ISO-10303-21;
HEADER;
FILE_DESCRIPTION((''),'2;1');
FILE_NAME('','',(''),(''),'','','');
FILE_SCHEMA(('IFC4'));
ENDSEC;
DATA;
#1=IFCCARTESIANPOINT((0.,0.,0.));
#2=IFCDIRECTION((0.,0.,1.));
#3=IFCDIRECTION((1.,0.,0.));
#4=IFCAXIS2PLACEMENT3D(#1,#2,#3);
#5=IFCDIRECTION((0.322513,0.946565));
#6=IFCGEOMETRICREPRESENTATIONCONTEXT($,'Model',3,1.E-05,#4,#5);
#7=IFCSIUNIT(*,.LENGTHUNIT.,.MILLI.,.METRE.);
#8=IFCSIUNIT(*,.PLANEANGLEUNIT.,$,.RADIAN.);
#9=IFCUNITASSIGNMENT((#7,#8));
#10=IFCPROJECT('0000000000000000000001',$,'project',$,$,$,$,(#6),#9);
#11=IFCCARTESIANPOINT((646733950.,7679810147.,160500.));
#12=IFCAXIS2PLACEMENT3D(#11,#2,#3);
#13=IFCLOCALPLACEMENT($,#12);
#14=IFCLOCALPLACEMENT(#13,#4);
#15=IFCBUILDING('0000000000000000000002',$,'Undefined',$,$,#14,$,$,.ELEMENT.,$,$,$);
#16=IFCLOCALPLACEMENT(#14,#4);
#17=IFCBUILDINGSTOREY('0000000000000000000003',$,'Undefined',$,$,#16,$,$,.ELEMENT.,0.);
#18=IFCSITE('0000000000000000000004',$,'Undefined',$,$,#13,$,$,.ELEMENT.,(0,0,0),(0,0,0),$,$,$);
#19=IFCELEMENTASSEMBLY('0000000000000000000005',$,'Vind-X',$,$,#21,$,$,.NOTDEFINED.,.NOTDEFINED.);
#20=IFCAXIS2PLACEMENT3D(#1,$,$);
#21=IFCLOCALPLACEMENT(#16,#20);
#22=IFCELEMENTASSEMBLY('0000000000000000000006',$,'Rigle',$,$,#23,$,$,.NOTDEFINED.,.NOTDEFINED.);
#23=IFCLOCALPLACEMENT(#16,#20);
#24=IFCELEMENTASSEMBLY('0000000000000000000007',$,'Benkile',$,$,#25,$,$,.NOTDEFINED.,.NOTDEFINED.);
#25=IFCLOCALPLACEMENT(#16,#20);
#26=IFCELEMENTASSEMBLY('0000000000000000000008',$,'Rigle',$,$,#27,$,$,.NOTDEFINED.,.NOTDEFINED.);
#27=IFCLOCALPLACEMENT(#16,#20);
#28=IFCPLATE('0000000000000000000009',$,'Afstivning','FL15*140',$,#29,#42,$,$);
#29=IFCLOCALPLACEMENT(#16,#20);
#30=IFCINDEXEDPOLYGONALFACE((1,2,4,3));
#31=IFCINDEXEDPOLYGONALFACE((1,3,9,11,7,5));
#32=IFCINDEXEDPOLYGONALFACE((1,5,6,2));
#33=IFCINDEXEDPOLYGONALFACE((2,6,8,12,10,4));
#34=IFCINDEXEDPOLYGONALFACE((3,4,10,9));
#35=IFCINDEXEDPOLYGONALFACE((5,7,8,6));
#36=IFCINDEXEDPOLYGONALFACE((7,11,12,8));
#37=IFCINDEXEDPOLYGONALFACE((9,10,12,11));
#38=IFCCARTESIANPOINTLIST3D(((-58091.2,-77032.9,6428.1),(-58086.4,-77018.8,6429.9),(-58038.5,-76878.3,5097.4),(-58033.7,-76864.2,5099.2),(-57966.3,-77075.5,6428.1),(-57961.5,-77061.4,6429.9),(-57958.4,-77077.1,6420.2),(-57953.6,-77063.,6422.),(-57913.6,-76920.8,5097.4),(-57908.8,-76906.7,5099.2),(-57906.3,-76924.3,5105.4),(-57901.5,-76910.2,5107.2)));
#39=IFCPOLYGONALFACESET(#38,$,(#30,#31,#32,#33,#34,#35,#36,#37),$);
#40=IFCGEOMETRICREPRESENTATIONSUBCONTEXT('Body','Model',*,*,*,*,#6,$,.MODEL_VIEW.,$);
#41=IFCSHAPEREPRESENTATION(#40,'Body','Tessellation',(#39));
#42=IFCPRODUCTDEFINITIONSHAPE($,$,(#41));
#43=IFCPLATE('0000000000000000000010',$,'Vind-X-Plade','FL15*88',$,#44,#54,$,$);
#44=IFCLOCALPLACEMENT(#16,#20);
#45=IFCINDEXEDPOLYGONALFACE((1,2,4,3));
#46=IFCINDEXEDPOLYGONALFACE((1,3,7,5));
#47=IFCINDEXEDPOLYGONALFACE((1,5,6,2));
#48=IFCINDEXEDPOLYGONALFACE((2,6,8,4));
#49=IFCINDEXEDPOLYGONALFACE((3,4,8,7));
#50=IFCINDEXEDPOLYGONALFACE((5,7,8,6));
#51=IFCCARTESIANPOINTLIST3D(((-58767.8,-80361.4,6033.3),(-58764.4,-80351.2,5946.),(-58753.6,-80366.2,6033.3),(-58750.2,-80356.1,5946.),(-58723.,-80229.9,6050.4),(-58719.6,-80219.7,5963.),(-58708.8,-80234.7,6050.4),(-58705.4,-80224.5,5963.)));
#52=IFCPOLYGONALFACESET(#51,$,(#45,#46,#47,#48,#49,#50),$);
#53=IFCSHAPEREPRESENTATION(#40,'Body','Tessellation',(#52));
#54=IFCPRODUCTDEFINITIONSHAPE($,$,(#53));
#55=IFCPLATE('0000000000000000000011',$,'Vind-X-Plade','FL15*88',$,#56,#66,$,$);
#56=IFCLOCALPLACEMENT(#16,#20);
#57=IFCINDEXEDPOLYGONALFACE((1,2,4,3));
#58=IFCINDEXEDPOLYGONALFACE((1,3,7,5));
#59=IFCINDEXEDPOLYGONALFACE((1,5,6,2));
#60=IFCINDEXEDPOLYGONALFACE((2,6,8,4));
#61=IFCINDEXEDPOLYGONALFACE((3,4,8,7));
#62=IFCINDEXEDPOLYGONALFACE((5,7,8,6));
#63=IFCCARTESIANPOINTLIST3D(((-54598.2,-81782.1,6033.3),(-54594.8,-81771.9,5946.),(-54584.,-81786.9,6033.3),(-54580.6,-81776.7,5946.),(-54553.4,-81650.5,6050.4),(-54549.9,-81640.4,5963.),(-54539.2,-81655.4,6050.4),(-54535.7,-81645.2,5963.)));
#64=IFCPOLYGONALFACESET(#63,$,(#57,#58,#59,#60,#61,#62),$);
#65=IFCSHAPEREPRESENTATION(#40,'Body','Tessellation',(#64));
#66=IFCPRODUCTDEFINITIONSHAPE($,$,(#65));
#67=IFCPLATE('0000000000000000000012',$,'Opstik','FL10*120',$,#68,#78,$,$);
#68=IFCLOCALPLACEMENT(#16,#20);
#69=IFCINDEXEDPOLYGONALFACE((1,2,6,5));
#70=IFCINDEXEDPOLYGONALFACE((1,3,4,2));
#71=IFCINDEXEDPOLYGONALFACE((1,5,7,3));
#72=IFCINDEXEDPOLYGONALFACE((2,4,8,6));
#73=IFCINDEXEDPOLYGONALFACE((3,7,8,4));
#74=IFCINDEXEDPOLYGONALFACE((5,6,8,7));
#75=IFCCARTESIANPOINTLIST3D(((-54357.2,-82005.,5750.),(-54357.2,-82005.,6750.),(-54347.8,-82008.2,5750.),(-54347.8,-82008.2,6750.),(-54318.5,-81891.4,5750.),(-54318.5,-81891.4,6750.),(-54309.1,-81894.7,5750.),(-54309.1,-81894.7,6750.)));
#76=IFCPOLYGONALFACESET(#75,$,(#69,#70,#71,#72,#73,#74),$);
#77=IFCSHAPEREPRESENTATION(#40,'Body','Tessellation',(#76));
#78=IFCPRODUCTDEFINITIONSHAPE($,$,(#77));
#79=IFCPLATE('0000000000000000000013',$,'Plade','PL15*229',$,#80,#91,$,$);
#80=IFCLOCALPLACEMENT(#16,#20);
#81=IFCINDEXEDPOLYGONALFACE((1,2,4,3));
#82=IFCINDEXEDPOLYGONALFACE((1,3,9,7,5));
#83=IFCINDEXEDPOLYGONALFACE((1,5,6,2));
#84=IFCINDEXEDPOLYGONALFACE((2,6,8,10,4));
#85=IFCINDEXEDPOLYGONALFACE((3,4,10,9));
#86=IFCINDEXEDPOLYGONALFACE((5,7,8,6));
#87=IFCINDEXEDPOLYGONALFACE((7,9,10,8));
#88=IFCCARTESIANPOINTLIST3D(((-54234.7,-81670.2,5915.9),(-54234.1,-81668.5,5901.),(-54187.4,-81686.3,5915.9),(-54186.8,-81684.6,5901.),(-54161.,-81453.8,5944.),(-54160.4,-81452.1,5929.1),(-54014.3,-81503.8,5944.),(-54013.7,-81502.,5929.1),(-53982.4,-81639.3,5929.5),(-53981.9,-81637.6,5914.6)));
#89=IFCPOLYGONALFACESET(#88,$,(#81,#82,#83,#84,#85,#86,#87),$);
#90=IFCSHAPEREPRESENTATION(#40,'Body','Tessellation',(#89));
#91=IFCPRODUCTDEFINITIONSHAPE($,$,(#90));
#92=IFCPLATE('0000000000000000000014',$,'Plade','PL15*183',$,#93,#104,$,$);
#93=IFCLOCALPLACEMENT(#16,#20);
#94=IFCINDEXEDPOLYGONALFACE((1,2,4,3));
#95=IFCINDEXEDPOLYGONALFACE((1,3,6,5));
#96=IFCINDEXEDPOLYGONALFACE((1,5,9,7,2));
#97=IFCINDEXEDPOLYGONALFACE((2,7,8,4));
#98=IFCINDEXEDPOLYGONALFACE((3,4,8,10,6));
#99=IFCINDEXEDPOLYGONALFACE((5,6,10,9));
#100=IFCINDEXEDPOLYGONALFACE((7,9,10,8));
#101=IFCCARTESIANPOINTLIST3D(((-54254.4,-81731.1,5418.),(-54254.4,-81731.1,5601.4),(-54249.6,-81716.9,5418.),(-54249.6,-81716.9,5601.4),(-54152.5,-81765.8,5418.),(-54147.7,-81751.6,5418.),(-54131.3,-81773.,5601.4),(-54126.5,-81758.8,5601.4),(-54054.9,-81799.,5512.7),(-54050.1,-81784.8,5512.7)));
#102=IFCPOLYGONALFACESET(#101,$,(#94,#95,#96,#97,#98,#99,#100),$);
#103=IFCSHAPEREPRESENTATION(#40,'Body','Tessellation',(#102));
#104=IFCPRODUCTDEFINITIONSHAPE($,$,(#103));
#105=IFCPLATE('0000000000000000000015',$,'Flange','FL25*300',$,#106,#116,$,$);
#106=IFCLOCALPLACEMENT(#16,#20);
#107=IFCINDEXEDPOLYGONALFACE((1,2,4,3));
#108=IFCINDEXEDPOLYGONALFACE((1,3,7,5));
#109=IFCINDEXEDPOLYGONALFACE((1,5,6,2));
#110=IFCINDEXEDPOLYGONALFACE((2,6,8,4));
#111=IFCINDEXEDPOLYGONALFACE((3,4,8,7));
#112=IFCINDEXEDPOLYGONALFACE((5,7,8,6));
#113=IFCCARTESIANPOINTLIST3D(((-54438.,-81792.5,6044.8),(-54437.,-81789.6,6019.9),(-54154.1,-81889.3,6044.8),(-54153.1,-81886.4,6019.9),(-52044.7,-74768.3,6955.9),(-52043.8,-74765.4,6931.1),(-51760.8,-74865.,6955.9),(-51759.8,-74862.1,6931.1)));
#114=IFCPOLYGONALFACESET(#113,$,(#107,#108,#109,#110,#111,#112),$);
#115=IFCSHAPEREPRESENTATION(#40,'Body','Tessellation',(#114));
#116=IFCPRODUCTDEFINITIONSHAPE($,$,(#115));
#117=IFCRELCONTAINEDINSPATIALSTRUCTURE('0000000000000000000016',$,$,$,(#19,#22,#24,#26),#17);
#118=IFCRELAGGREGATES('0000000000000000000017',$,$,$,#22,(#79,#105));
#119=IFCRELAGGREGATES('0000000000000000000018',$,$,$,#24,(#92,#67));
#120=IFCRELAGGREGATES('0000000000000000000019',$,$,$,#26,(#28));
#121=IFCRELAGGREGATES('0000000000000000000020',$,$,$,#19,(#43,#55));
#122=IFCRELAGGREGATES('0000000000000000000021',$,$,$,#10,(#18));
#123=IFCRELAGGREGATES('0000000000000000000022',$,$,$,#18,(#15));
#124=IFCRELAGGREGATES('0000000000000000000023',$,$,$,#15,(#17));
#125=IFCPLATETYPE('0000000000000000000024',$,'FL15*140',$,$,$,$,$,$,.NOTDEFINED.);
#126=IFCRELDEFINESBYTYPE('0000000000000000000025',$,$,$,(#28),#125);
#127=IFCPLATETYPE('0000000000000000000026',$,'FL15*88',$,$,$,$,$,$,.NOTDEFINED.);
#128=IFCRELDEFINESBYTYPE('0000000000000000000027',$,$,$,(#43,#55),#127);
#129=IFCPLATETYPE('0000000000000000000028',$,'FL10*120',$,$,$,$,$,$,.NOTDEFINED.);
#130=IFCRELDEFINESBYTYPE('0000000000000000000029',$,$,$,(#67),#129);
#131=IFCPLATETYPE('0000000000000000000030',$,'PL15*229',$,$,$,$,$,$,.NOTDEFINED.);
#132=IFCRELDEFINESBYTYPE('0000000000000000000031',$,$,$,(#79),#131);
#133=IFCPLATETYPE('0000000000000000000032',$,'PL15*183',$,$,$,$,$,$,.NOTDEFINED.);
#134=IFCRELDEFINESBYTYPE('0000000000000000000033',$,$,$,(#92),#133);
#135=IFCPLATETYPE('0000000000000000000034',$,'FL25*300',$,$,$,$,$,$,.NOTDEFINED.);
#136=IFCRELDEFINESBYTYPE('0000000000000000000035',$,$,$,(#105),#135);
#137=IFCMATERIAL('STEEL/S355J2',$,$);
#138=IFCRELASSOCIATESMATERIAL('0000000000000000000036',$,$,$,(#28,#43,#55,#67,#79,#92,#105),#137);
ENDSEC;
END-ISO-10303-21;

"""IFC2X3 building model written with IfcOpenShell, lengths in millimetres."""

from ifc_helpers import new_model, si_unit, direction, frame, origin_with_axes, place, context, subcontext, project, spatial, polyline, outline, extrude, clip, halfspace, material, type_object, element, aggregate, save


model = new_model("IFC2X3")

# Units and contexts
model_context = context("Model", 3, precision=1e-05, world=origin_with_axes(), true_north=direction((0.322513, 0.946565)))
body_context = subcontext(model_context, "Body", "Model", "MODEL_VIEW")
ifc_project = project(units=[si_unit("LENGTHUNIT", "METRE", prefix="MILLI"), si_unit("PLANEANGLEUNIT", "RADIAN")], contexts=[model_context])

# Site, building, storey
site_placement = place(None, frame((646733950.0, 7679810147.0, 160500.0), z_axis=(0.0, 0.0, 1.0), x_axis=(1.0, 0.0, 0.0)))
site = spatial("IfcSite", under=ifc_project, at=site_placement, Name="Undefined", CompositionType="ELEMENT", RefLatitude=(0, 0, 0), RefLongitude=(0, 0, 0))
building_placement = place(site_placement, origin_with_axes())
building = spatial("IfcBuilding", under=site, at=building_placement, Name="Undefined", CompositionType="ELEMENT")
storey_placement = place(building_placement, origin_with_axes())
storey = spatial("IfcBuildingStorey", under=building, at=storey_placement, Name="Undefined", CompositionType="ELEMENT", Elevation=0.0)

# Element assembly
assembly_1_placement = place(storey_placement, origin_with_axes())
assembly_1 = element("IfcElementAssembly", 1, at=assembly_1_placement, inside=storey, Name="Vind-X", AssemblyPlace="NOTDEFINED", PredefinedType="NOTDEFINED")

# Shared definitions
ifc_material_1 = material(Name="STEEL/S355J2")

# Element assemblies
assembly_2_placement = place(storey_placement, origin_with_axes())
assembly_2 = element("IfcElementAssembly", 2, at=assembly_2_placement, inside=storey, Name="Rigle", AssemblyPlace="NOTDEFINED", PredefinedType="NOTDEFINED")
assembly_3_placement = place(storey_placement, origin_with_axes())
assembly_3 = element("IfcElementAssembly", 3, at=assembly_3_placement, inside=storey, Name="Benkile", AssemblyPlace="NOTDEFINED", PredefinedType="NOTDEFINED")

# Shared definitions
plate_type_1 = type_object("IfcPlateType", Name="FL15*140", PredefinedType="NOTDEFINED")

# Element assembly, plate
assembly_4_placement = place(storey_placement, origin_with_axes())
assembly_4 = element("IfcElementAssembly", 4, at=assembly_4_placement, inside=storey, Name="Rigle", AssemblyPlace="NOTDEFINED", PredefinedType="NOTDEFINED")
plate_1_placement = place(assembly_4_placement, frame((-57903.6, -76916.4, 5098.3), z_axis=(0.320109, 0.93951, 0.121869), x_axis=(-0.946565, 0.322513, 0.0)))
plate_1 = element("IfcPlate", 5, at=plate_1_placement, type_object=plate_type_1, material=ifc_material_1, Name="Afstivning", Description="FL15*140", context=body_context, shape_type="SweptSolid", body=[
    extrude(outline(polyline([(0.0, 8.0), (8.0, 0.0), (140.0, 0.0), (140.0, 1340.7), (8.0, 1340.7), (0.0, 1332.7), (0.0, 8.0)])), frame((0.0, 0.0, -7.5), z_axis=(0.0, 0.0, 1.0), x_axis=(1.0, 0.0, 0.0)), (0.0, 0.0, 1.0), 15.0),
])

# Plates
plate_type_2 = type_object("IfcPlateType", Name="FL15*88", PredefinedType="NOTDEFINED")
plate_2_placement = place(assembly_1_placement, frame((-58712.5, -80222.1, 5963.0), z_axis=(-0.946565, 0.322513, 0.0), x_axis=(-0.320109, -0.93951, -0.121869)))
plate_2 = element("IfcPlate", 6, at=plate_2_placement, type_object=plate_type_2, material=ifc_material_1, Name="Vind-X-Plade", Description="FL15*88", context=body_context, shape_type="SweptSolid", body=[
    extrude(outline(polyline([(0.0, 0.0), (140.0, 0.0), (140.0, 88.0), (0.0, 88.0), (0.0, 0.0)])), frame((0.0, 0.0, -7.5), z_axis=(0.0, 0.0, 1.0), x_axis=(1.0, 0.0, 0.0)), (0.0, 0.0, 1.0), 15.0),
])
plate_3_placement = place(assembly_1_placement, frame((-54542.8, -81642.8, 5963.0), z_axis=(-0.946565, 0.322513, 0.0), x_axis=(-0.320109, -0.93951, -0.121869)))
plate_3 = element("IfcPlate", 7, at=plate_3_placement, type_object=plate_type_2, material=ifc_material_1, Name="Vind-X-Plade", Description="FL15*88", context=body_context, shape_type="SweptSolid", body=[
    extrude(outline(polyline([(0.0, 0.0), (140.0, 0.0), (140.0, 88.0), (0.0, 88.0), (0.0, 0.0)])), frame((0.0, 0.0, -7.5), z_axis=(0.0, 0.0, 1.0), x_axis=(1.0, 0.0, 0.0)), (0.0, 0.0, 1.0), 15.0),
])
plate_type_3 = type_object("IfcPlateType", Name="FL10*120", PredefinedType="NOTDEFINED")
plate_4_placement = place(assembly_3_placement, frame((-54313.8, -81893.0, 5750.0), z_axis=(0.946565, -0.322513, 0.0), x_axis=(0.0, 0.0, 1.0)))
plate_4 = element("IfcPlate", 8, at=plate_4_placement, type_object=plate_type_3, material=ifc_material_1, Name="Opstik", Description="FL10*120", context=body_context, shape_type="SweptSolid", body=[
    extrude(outline(polyline([(0.0, 0.0), (1000.0, 0.0), (1000.0, 120.0), (1000.0, 120.0), (0.0, 120.0), (0.0, 120.0), (0.0, 0.0)])), frame((0.0, 0.0, -5.0), z_axis=(0.0, 0.0, 1.0), x_axis=(1.0, 0.0, 0.0)), (0.0, 0.0, 1.0), 10.0),
])
plate_type_4 = type_object("IfcPlateType", Name="PL15*229", PredefinedType="NOTDEFINED")
plate_5_placement = place(assembly_2_placement, frame((-54160.7, -81452.9, 5936.5), z_axis=(-0.039304, -0.115357, 0.992546), x_axis=(-0.320109, -0.93951, -0.121869)))
plate_5 = element("IfcPlate", 9, at=plate_5_placement, type_object=plate_type_4, material=ifc_material_1, Name="Plade", Description="PL15*229", context=body_context, shape_type="SweptSolid", body=[
    extrude(outline(polyline([(0.0, 0.0), (230.3, 0.0), (230.3, 50.0), (118.9, 228.8), (0.0, 154.9), (0.0, 0.0)])), frame((0.0, 0.0, -7.5), z_axis=(0.0, 0.0, 1.0), x_axis=(1.0, 0.0, 0.0)), (0.0, 0.0, 1.0), 15.0),
])
plate_type_5 = type_object("IfcPlateType", Name="PL15*183", PredefinedType="NOTDEFINED")
plate_6_placement = place(assembly_3_placement, frame((-54252.0, -81724.0, 5601.4), z_axis=(-0.322513, -0.946565, 0.0), x_axis=(0.0, 0.0, -1.0)))
plate_6 = element("IfcPlate", 10, at=plate_6_placement, type_object=plate_type_5, material=ifc_material_1, Name="Plade", Description="PL15*183", context=body_context, shape_type="SweptSolid", body=[
    extrude(outline(polyline([(0.0, 0.0), (183.4, 0.0), (183.4, 107.7), (88.7, 210.8), (0.0, 130.0), (0.0, 0.0)])), frame((0.0, 0.0, -7.5), z_axis=(0.0, 0.0, 1.0), x_axis=(1.0, 0.0, 0.0)), (0.0, 0.0, 1.0), 15.0),
])
plate_type_6 = type_object("IfcPlateType", Name="FL25*300", PredefinedType="NOTDEFINED")
plate_7_placement = place(assembly_2_placement, frame((-54295.6, -81839.5, 6032.4), z_axis=(0.039304, 0.115357, -0.992546), x_axis=(0.320109, 0.93951, 0.121869)))
plate_7 = element("IfcPlate", 11, at=plate_7_placement, type_object=plate_type_6, material=ifc_material_1, Name="Flange", Description="FL25*300", context=body_context, shape_type="Clipping", body=[
    clip(extrude(outline(polyline([(0.0, -150.0), (0.0, 150.0), (7476.5, 150.0), (7476.5, -150.0), (0.0, -150.0)])), frame((0.0, 0.0, -12.5), z_axis=(0.0, 0.0, 1.0), x_axis=(1.0, 0.0, 0.0)), (0.0, 0.0, 1.0), 25.0), halfspace(frame((7476.5, 0.0, 287.5), z_axis=(1.0, 0.0, 0.0), x_axis=(0.0, 1.0, 0.0)), False)),
])
aggregate(assembly_2, [plate_5, plate_7])

aggregate(assembly_3, [plate_6, plate_4])

aggregate(assembly_4, [plate_1])

aggregate(assembly_1, [plate_2, plate_3])

save(model, "model.ifc")
